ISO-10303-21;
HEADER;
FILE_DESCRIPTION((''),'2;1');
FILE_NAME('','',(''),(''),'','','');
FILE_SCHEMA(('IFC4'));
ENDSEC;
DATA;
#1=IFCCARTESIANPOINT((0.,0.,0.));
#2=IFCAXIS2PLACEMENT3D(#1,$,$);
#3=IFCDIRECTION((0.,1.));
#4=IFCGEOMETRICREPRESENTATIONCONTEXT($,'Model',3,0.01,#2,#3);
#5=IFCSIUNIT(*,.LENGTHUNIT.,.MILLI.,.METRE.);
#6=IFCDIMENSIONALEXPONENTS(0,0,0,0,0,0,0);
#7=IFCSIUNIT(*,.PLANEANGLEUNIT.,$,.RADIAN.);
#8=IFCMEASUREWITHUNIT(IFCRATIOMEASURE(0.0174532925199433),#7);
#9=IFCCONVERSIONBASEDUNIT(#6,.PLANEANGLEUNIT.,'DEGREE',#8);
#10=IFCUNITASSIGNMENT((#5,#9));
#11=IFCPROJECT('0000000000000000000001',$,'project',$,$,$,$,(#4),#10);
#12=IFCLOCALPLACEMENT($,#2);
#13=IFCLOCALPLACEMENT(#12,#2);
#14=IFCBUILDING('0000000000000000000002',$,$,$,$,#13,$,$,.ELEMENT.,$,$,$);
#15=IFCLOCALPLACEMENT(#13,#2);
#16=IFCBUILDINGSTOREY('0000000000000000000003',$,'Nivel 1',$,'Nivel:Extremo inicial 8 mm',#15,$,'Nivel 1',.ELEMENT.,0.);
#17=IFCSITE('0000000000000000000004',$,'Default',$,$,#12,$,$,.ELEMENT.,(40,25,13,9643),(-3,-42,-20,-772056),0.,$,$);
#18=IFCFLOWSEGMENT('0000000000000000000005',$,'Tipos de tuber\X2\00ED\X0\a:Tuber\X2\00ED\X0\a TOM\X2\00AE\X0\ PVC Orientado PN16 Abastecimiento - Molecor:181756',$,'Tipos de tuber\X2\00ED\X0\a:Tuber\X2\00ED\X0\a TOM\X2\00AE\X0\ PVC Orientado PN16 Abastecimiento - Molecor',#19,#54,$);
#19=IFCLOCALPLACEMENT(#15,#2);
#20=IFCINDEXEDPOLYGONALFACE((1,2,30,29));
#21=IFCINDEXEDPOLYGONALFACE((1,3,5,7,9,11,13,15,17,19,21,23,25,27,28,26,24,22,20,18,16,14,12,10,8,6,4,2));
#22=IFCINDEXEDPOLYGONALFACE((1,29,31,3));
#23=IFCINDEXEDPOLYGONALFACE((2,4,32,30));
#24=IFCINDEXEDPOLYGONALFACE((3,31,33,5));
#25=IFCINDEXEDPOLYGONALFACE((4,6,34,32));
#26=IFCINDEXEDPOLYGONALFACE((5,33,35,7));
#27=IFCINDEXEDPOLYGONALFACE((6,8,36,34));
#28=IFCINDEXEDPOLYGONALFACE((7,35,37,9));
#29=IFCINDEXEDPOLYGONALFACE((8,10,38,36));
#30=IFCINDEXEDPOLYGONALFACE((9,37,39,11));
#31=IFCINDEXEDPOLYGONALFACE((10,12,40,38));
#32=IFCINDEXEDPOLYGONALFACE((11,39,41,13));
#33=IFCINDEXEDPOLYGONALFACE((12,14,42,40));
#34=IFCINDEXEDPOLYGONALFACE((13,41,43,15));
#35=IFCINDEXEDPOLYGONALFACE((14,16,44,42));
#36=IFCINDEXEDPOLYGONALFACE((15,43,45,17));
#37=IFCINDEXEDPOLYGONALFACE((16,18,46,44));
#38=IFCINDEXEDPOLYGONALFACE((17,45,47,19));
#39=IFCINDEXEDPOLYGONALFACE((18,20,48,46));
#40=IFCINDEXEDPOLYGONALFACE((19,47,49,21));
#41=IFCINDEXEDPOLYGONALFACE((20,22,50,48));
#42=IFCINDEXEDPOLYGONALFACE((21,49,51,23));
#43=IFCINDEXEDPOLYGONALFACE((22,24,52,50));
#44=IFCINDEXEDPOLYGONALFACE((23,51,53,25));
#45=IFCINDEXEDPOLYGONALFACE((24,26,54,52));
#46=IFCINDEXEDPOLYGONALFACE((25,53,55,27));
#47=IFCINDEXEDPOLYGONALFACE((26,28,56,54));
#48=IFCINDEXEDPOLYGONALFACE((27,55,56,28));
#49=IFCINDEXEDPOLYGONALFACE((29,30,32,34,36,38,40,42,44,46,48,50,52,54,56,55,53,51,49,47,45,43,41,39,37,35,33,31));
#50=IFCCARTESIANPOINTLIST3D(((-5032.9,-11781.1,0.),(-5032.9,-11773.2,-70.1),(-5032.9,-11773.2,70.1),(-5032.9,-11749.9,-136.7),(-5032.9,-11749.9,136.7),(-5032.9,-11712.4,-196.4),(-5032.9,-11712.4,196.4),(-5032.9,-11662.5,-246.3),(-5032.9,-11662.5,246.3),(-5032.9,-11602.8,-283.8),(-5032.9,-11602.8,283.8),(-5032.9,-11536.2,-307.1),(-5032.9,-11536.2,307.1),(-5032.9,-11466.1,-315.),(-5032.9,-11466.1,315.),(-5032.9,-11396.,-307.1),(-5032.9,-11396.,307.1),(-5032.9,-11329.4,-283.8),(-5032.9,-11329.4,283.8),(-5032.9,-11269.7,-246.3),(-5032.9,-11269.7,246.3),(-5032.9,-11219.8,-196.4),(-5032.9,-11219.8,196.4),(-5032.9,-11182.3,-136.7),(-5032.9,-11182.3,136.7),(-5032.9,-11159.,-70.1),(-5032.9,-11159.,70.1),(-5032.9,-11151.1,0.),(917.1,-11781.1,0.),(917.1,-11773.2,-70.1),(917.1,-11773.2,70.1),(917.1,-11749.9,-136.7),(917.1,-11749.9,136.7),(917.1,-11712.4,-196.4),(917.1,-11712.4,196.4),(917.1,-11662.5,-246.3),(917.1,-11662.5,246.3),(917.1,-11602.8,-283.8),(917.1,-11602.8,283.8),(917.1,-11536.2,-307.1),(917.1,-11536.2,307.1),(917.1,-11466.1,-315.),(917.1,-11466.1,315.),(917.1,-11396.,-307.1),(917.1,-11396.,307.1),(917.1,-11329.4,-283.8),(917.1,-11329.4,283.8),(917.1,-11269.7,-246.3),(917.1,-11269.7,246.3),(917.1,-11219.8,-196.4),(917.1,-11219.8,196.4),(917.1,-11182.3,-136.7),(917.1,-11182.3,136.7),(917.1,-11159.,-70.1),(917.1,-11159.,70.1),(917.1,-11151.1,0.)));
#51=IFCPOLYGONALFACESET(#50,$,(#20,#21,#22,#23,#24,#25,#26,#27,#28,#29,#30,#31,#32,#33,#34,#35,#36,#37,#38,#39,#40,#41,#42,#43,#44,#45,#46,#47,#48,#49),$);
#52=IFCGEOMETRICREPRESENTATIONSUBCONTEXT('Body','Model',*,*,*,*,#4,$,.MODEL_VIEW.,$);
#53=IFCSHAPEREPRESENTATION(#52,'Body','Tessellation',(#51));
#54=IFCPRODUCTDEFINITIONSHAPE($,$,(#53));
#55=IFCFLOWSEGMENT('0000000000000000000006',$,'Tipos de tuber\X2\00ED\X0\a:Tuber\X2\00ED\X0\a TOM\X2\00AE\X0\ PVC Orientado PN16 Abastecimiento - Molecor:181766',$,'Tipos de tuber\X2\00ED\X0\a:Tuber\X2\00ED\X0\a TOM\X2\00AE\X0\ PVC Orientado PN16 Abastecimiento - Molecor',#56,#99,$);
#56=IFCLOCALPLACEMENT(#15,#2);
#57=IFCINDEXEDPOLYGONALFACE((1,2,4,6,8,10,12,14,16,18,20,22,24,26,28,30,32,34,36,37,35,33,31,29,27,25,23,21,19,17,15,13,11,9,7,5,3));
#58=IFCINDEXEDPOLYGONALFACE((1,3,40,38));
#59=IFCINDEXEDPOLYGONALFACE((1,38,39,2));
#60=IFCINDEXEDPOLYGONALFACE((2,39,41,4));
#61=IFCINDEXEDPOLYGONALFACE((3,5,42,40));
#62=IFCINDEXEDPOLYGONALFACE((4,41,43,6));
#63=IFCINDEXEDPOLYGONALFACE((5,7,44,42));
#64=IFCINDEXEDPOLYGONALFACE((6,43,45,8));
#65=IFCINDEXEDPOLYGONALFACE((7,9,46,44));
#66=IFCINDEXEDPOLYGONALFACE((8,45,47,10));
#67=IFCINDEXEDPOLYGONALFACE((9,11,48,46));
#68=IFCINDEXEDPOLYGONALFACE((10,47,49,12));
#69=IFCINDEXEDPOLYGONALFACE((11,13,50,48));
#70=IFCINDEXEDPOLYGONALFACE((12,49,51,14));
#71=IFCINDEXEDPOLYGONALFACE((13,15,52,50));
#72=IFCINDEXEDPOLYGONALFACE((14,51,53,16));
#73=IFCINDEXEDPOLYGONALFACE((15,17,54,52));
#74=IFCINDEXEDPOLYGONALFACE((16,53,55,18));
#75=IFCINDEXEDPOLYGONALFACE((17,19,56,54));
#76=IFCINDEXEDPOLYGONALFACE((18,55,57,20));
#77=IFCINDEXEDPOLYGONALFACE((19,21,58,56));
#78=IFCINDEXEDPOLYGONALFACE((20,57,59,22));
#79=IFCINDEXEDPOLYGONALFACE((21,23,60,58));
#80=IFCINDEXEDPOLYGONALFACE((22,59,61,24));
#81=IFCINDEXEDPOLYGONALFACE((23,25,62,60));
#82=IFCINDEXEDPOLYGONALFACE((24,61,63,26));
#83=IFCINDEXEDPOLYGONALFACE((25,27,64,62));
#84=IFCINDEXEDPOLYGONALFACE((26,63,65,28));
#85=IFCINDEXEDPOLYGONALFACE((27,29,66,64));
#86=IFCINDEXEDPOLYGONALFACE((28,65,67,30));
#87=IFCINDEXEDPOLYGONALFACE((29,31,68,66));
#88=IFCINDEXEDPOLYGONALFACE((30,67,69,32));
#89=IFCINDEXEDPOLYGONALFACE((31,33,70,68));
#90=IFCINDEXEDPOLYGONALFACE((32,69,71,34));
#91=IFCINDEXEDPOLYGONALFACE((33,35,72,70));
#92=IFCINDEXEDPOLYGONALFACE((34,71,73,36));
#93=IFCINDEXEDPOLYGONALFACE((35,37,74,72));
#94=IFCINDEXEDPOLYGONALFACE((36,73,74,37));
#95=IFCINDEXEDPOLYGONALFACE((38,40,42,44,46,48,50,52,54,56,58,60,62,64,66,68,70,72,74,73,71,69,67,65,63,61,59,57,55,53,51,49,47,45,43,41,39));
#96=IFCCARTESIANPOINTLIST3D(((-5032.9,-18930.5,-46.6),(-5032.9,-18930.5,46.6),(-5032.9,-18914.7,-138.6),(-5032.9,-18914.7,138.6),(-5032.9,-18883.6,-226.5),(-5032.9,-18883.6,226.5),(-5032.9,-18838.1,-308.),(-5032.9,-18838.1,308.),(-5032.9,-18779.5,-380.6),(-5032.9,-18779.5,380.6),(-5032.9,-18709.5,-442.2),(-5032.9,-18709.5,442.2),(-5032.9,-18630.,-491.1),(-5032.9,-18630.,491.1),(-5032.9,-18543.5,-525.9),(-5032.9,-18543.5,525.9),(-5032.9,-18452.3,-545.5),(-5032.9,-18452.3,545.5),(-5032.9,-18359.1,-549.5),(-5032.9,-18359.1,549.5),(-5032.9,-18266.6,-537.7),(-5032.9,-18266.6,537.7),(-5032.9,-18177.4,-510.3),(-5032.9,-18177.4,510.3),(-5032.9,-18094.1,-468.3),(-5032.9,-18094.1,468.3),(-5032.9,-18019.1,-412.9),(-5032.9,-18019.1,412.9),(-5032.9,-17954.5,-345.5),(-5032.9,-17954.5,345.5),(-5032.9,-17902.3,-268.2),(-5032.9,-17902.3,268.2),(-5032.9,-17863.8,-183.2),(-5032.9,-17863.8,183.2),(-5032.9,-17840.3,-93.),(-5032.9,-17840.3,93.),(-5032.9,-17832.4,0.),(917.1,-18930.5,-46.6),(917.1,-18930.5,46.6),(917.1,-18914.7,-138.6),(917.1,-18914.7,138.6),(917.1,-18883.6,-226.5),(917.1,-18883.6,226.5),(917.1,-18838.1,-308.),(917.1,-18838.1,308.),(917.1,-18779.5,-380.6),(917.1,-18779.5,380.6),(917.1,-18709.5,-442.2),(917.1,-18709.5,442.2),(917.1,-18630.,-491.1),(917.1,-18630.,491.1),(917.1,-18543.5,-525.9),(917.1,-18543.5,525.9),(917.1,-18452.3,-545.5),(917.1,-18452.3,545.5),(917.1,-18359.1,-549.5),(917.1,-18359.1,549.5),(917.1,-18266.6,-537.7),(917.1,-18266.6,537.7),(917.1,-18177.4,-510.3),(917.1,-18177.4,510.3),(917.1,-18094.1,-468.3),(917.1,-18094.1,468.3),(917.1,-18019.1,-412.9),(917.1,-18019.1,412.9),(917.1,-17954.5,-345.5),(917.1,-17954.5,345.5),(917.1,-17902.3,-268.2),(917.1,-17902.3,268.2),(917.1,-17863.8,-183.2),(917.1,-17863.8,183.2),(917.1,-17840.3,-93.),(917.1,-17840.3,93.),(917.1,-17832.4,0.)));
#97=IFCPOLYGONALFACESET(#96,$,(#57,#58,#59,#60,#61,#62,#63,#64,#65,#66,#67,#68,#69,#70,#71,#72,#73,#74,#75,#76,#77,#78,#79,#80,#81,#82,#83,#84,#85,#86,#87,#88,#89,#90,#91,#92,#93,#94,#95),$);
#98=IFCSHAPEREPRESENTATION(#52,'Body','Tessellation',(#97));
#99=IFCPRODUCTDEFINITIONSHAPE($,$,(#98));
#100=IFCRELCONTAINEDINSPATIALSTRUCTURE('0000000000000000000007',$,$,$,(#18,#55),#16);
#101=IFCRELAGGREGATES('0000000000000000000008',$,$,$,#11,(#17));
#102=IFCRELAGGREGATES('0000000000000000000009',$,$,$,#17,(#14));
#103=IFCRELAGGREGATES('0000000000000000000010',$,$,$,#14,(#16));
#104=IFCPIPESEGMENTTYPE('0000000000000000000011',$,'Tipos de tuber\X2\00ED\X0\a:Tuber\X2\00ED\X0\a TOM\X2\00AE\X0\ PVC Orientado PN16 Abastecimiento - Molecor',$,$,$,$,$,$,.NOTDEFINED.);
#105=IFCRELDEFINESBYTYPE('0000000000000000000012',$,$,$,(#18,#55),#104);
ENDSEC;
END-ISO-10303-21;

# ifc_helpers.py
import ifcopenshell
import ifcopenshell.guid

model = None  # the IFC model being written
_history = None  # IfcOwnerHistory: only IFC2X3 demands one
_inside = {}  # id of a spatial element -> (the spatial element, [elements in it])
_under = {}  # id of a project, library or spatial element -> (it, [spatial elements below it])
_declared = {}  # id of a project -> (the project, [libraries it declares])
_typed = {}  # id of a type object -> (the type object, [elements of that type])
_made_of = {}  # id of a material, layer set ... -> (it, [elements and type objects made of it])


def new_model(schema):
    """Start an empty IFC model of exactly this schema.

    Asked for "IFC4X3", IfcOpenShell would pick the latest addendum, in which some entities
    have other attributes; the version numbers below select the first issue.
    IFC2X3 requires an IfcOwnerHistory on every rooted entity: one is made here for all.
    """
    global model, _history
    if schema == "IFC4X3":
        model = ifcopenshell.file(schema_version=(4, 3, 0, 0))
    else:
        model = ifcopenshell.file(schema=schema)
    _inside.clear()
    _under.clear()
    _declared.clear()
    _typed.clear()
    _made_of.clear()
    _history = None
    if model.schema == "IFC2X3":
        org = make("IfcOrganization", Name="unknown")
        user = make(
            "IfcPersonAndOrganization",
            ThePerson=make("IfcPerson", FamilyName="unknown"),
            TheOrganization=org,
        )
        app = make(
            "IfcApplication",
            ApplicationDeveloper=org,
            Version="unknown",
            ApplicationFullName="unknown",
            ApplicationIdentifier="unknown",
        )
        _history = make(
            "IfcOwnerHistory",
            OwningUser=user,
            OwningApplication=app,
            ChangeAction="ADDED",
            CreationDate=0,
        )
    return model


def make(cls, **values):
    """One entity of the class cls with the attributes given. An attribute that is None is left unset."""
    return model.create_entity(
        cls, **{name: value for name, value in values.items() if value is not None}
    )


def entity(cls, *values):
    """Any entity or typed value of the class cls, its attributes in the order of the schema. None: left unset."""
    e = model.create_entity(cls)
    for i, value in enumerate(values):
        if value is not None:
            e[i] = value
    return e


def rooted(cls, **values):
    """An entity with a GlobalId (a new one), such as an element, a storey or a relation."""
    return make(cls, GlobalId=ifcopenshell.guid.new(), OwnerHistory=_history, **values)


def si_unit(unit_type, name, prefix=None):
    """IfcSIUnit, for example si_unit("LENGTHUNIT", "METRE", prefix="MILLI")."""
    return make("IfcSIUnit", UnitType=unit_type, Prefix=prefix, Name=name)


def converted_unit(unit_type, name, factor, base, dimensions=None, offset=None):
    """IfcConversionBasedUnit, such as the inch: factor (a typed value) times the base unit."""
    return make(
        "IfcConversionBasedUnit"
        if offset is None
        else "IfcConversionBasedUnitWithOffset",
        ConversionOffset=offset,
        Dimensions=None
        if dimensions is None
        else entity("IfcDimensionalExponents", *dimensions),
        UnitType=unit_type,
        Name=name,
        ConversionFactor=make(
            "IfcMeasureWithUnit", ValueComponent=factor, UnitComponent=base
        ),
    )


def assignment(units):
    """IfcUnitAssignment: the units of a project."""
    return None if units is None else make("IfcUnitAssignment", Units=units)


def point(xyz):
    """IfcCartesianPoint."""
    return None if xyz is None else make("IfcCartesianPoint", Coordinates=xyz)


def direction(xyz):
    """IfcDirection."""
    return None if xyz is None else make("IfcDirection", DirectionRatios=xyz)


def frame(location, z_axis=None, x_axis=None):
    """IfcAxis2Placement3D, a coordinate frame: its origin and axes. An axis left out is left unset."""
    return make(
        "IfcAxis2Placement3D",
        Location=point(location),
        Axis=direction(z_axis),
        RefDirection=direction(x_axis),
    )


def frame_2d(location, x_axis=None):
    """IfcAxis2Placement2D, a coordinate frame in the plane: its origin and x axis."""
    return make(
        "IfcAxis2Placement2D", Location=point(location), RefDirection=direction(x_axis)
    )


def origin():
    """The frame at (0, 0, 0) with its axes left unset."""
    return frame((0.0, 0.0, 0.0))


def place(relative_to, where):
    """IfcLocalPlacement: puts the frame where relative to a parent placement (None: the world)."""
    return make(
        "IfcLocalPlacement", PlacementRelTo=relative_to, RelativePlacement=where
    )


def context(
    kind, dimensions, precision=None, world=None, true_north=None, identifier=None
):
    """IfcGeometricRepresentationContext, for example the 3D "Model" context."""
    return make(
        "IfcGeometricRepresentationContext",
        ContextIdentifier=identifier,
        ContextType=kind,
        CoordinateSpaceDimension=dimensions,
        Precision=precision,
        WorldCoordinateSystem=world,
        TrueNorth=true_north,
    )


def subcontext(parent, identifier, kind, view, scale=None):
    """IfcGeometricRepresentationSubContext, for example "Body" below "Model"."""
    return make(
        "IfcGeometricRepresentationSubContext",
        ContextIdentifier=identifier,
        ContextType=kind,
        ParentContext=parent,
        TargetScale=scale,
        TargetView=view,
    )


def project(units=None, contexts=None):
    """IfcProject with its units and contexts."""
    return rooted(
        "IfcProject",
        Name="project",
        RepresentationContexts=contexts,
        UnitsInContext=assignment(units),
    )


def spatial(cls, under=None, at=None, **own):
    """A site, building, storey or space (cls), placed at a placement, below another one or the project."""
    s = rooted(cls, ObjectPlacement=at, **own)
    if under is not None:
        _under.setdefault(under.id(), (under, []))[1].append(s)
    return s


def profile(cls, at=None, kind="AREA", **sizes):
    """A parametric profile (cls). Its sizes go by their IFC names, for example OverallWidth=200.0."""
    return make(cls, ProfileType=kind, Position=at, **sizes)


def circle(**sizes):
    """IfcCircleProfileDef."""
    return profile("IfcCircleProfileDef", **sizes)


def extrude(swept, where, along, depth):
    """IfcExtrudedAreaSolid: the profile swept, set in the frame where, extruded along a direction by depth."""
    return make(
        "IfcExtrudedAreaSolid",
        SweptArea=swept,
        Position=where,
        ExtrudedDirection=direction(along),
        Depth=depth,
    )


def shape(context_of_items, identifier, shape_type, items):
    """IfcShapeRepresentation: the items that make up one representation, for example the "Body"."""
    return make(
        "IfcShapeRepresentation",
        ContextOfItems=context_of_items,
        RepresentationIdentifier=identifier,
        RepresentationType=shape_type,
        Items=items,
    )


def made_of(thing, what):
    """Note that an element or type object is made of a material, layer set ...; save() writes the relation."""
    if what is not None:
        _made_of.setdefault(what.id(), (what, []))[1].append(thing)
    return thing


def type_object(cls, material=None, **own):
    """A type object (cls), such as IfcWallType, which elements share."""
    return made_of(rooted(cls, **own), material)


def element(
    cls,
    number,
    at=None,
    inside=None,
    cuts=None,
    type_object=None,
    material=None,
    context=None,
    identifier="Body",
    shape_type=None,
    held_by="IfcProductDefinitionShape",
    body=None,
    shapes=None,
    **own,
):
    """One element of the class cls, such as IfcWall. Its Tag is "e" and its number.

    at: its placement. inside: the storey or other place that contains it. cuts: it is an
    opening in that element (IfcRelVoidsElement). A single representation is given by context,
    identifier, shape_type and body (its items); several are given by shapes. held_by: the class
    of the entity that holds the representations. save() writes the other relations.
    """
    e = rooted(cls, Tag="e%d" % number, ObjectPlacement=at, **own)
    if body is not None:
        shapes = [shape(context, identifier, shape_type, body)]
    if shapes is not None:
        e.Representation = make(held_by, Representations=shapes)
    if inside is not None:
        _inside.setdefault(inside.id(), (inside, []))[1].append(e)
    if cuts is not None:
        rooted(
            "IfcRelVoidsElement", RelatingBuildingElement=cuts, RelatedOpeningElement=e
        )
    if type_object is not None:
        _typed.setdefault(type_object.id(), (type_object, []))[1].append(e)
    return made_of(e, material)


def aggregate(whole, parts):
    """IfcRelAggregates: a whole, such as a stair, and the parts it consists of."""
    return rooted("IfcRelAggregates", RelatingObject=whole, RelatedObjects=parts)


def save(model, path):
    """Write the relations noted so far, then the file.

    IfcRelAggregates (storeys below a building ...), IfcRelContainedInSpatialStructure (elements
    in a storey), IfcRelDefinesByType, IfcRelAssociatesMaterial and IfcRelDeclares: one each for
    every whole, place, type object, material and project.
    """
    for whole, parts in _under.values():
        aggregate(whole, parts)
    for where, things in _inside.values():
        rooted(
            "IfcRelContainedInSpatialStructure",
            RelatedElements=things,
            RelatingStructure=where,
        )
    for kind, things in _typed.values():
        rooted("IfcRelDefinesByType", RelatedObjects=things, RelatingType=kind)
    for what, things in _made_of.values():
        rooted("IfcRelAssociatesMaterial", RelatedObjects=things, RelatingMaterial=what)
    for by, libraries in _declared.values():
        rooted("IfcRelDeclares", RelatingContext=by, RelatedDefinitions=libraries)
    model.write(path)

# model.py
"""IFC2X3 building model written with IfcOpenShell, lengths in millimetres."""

from ifc_helpers import new_model, entity, si_unit, converted_unit, direction, frame, frame_2d, origin, place, context, subcontext, project, spatial, circle, extrude, type_object, element, save


model = new_model("IFC2X3")

# Units and contexts
model_context = context("Model", 3, precision=0.01, world=origin(), true_north=direction((0.0, 1.0)))
body_context = subcontext(model_context, "Body", "Model", "MODEL_VIEW")
ifc_project = project(units=[si_unit("LENGTHUNIT", "METRE", prefix="MILLI"), converted_unit("PLANEANGLEUNIT", "DEGREE", entity("IfcRatioMeasure", 0.0174532925199433), si_unit("PLANEANGLEUNIT", "RADIAN"), dimensions=[0, 0, 0, 0, 0, 0, 0])], contexts=[model_context])

# Site, building, storey
site_placement = place(None, origin())
site = spatial("IfcSite", under=ifc_project, at=site_placement, Name="Default", CompositionType="ELEMENT", RefLatitude=(40, 25, 13, 9643), RefLongitude=(-3, -42, -20, -772056), RefElevation=0.0)
building_placement = place(site_placement, origin())
building = spatial("IfcBuilding", under=site, at=building_placement, CompositionType="ELEMENT")
storey_placement = place(building_placement, origin())
storey = spatial("IfcBuildingStorey", under=building, at=storey_placement, Name="Nivel 1", ObjectType="Nivel:Extremo inicial 8 mm", LongName="Nivel 1", CompositionType="ELEMENT", Elevation=0.0)

# Flow segments
pipe_segment_type_1 = type_object("IfcPipeSegmentType", Name="Tipos de tubería:Tubería TOM® PVC Orientado PN16 Abastecimiento - Molecor", PredefinedType="NOTDEFINED")
flow_segment_1_placement = place(storey_placement, frame((-5032.9, -11782.7, -316.6)))
element("IfcFlowSegment", 1, at=flow_segment_1_placement, inside=storey, type_object=pipe_segment_type_1, Name="Tipos de tubería:Tubería TOM® PVC Orientado PN16 Abastecimiento - Molecor:181756", ObjectType="Tipos de tubería:Tubería TOM® PVC Orientado PN16 Abastecimiento - Molecor", context=body_context, shape_type="SweptSolid", body=[
    extrude(circle(Radius=315.0, at=frame_2d((0.0, 0.0), x_axis=(1.0, 0.0))), frame((0.0, 316.6, 316.6), z_axis=(1.0, 0.0, 0.0), x_axis=(0.0, 1.0, 0.0)), (0.0, 0.0, 1.0), 5950.0),
])
flow_segment_2_placement = place(storey_placement, frame((-5032.9, -18934.0, -551.6)))
element("IfcFlowSegment", 2, at=flow_segment_2_placement, inside=storey, type_object=pipe_segment_type_1, Name="Tipos de tubería:Tubería TOM® PVC Orientado PN16 Abastecimiento - Molecor:181766", ObjectType="Tipos de tubería:Tubería TOM® PVC Orientado PN16 Abastecimiento - Molecor", context=body_context, shape_type="SweptSolid", body=[
    extrude(circle(Radius=550.0, at=frame_2d((0.0, 0.0), x_axis=(1.0, 0.0))), frame((0.0, 551.6, 551.6), z_axis=(1.0, 0.0, 0.0), x_axis=(0.0, 1.0, 0.0)), (0.0, 0.0, 1.0), 5950.0),
])

save(model, "model.ifc")
